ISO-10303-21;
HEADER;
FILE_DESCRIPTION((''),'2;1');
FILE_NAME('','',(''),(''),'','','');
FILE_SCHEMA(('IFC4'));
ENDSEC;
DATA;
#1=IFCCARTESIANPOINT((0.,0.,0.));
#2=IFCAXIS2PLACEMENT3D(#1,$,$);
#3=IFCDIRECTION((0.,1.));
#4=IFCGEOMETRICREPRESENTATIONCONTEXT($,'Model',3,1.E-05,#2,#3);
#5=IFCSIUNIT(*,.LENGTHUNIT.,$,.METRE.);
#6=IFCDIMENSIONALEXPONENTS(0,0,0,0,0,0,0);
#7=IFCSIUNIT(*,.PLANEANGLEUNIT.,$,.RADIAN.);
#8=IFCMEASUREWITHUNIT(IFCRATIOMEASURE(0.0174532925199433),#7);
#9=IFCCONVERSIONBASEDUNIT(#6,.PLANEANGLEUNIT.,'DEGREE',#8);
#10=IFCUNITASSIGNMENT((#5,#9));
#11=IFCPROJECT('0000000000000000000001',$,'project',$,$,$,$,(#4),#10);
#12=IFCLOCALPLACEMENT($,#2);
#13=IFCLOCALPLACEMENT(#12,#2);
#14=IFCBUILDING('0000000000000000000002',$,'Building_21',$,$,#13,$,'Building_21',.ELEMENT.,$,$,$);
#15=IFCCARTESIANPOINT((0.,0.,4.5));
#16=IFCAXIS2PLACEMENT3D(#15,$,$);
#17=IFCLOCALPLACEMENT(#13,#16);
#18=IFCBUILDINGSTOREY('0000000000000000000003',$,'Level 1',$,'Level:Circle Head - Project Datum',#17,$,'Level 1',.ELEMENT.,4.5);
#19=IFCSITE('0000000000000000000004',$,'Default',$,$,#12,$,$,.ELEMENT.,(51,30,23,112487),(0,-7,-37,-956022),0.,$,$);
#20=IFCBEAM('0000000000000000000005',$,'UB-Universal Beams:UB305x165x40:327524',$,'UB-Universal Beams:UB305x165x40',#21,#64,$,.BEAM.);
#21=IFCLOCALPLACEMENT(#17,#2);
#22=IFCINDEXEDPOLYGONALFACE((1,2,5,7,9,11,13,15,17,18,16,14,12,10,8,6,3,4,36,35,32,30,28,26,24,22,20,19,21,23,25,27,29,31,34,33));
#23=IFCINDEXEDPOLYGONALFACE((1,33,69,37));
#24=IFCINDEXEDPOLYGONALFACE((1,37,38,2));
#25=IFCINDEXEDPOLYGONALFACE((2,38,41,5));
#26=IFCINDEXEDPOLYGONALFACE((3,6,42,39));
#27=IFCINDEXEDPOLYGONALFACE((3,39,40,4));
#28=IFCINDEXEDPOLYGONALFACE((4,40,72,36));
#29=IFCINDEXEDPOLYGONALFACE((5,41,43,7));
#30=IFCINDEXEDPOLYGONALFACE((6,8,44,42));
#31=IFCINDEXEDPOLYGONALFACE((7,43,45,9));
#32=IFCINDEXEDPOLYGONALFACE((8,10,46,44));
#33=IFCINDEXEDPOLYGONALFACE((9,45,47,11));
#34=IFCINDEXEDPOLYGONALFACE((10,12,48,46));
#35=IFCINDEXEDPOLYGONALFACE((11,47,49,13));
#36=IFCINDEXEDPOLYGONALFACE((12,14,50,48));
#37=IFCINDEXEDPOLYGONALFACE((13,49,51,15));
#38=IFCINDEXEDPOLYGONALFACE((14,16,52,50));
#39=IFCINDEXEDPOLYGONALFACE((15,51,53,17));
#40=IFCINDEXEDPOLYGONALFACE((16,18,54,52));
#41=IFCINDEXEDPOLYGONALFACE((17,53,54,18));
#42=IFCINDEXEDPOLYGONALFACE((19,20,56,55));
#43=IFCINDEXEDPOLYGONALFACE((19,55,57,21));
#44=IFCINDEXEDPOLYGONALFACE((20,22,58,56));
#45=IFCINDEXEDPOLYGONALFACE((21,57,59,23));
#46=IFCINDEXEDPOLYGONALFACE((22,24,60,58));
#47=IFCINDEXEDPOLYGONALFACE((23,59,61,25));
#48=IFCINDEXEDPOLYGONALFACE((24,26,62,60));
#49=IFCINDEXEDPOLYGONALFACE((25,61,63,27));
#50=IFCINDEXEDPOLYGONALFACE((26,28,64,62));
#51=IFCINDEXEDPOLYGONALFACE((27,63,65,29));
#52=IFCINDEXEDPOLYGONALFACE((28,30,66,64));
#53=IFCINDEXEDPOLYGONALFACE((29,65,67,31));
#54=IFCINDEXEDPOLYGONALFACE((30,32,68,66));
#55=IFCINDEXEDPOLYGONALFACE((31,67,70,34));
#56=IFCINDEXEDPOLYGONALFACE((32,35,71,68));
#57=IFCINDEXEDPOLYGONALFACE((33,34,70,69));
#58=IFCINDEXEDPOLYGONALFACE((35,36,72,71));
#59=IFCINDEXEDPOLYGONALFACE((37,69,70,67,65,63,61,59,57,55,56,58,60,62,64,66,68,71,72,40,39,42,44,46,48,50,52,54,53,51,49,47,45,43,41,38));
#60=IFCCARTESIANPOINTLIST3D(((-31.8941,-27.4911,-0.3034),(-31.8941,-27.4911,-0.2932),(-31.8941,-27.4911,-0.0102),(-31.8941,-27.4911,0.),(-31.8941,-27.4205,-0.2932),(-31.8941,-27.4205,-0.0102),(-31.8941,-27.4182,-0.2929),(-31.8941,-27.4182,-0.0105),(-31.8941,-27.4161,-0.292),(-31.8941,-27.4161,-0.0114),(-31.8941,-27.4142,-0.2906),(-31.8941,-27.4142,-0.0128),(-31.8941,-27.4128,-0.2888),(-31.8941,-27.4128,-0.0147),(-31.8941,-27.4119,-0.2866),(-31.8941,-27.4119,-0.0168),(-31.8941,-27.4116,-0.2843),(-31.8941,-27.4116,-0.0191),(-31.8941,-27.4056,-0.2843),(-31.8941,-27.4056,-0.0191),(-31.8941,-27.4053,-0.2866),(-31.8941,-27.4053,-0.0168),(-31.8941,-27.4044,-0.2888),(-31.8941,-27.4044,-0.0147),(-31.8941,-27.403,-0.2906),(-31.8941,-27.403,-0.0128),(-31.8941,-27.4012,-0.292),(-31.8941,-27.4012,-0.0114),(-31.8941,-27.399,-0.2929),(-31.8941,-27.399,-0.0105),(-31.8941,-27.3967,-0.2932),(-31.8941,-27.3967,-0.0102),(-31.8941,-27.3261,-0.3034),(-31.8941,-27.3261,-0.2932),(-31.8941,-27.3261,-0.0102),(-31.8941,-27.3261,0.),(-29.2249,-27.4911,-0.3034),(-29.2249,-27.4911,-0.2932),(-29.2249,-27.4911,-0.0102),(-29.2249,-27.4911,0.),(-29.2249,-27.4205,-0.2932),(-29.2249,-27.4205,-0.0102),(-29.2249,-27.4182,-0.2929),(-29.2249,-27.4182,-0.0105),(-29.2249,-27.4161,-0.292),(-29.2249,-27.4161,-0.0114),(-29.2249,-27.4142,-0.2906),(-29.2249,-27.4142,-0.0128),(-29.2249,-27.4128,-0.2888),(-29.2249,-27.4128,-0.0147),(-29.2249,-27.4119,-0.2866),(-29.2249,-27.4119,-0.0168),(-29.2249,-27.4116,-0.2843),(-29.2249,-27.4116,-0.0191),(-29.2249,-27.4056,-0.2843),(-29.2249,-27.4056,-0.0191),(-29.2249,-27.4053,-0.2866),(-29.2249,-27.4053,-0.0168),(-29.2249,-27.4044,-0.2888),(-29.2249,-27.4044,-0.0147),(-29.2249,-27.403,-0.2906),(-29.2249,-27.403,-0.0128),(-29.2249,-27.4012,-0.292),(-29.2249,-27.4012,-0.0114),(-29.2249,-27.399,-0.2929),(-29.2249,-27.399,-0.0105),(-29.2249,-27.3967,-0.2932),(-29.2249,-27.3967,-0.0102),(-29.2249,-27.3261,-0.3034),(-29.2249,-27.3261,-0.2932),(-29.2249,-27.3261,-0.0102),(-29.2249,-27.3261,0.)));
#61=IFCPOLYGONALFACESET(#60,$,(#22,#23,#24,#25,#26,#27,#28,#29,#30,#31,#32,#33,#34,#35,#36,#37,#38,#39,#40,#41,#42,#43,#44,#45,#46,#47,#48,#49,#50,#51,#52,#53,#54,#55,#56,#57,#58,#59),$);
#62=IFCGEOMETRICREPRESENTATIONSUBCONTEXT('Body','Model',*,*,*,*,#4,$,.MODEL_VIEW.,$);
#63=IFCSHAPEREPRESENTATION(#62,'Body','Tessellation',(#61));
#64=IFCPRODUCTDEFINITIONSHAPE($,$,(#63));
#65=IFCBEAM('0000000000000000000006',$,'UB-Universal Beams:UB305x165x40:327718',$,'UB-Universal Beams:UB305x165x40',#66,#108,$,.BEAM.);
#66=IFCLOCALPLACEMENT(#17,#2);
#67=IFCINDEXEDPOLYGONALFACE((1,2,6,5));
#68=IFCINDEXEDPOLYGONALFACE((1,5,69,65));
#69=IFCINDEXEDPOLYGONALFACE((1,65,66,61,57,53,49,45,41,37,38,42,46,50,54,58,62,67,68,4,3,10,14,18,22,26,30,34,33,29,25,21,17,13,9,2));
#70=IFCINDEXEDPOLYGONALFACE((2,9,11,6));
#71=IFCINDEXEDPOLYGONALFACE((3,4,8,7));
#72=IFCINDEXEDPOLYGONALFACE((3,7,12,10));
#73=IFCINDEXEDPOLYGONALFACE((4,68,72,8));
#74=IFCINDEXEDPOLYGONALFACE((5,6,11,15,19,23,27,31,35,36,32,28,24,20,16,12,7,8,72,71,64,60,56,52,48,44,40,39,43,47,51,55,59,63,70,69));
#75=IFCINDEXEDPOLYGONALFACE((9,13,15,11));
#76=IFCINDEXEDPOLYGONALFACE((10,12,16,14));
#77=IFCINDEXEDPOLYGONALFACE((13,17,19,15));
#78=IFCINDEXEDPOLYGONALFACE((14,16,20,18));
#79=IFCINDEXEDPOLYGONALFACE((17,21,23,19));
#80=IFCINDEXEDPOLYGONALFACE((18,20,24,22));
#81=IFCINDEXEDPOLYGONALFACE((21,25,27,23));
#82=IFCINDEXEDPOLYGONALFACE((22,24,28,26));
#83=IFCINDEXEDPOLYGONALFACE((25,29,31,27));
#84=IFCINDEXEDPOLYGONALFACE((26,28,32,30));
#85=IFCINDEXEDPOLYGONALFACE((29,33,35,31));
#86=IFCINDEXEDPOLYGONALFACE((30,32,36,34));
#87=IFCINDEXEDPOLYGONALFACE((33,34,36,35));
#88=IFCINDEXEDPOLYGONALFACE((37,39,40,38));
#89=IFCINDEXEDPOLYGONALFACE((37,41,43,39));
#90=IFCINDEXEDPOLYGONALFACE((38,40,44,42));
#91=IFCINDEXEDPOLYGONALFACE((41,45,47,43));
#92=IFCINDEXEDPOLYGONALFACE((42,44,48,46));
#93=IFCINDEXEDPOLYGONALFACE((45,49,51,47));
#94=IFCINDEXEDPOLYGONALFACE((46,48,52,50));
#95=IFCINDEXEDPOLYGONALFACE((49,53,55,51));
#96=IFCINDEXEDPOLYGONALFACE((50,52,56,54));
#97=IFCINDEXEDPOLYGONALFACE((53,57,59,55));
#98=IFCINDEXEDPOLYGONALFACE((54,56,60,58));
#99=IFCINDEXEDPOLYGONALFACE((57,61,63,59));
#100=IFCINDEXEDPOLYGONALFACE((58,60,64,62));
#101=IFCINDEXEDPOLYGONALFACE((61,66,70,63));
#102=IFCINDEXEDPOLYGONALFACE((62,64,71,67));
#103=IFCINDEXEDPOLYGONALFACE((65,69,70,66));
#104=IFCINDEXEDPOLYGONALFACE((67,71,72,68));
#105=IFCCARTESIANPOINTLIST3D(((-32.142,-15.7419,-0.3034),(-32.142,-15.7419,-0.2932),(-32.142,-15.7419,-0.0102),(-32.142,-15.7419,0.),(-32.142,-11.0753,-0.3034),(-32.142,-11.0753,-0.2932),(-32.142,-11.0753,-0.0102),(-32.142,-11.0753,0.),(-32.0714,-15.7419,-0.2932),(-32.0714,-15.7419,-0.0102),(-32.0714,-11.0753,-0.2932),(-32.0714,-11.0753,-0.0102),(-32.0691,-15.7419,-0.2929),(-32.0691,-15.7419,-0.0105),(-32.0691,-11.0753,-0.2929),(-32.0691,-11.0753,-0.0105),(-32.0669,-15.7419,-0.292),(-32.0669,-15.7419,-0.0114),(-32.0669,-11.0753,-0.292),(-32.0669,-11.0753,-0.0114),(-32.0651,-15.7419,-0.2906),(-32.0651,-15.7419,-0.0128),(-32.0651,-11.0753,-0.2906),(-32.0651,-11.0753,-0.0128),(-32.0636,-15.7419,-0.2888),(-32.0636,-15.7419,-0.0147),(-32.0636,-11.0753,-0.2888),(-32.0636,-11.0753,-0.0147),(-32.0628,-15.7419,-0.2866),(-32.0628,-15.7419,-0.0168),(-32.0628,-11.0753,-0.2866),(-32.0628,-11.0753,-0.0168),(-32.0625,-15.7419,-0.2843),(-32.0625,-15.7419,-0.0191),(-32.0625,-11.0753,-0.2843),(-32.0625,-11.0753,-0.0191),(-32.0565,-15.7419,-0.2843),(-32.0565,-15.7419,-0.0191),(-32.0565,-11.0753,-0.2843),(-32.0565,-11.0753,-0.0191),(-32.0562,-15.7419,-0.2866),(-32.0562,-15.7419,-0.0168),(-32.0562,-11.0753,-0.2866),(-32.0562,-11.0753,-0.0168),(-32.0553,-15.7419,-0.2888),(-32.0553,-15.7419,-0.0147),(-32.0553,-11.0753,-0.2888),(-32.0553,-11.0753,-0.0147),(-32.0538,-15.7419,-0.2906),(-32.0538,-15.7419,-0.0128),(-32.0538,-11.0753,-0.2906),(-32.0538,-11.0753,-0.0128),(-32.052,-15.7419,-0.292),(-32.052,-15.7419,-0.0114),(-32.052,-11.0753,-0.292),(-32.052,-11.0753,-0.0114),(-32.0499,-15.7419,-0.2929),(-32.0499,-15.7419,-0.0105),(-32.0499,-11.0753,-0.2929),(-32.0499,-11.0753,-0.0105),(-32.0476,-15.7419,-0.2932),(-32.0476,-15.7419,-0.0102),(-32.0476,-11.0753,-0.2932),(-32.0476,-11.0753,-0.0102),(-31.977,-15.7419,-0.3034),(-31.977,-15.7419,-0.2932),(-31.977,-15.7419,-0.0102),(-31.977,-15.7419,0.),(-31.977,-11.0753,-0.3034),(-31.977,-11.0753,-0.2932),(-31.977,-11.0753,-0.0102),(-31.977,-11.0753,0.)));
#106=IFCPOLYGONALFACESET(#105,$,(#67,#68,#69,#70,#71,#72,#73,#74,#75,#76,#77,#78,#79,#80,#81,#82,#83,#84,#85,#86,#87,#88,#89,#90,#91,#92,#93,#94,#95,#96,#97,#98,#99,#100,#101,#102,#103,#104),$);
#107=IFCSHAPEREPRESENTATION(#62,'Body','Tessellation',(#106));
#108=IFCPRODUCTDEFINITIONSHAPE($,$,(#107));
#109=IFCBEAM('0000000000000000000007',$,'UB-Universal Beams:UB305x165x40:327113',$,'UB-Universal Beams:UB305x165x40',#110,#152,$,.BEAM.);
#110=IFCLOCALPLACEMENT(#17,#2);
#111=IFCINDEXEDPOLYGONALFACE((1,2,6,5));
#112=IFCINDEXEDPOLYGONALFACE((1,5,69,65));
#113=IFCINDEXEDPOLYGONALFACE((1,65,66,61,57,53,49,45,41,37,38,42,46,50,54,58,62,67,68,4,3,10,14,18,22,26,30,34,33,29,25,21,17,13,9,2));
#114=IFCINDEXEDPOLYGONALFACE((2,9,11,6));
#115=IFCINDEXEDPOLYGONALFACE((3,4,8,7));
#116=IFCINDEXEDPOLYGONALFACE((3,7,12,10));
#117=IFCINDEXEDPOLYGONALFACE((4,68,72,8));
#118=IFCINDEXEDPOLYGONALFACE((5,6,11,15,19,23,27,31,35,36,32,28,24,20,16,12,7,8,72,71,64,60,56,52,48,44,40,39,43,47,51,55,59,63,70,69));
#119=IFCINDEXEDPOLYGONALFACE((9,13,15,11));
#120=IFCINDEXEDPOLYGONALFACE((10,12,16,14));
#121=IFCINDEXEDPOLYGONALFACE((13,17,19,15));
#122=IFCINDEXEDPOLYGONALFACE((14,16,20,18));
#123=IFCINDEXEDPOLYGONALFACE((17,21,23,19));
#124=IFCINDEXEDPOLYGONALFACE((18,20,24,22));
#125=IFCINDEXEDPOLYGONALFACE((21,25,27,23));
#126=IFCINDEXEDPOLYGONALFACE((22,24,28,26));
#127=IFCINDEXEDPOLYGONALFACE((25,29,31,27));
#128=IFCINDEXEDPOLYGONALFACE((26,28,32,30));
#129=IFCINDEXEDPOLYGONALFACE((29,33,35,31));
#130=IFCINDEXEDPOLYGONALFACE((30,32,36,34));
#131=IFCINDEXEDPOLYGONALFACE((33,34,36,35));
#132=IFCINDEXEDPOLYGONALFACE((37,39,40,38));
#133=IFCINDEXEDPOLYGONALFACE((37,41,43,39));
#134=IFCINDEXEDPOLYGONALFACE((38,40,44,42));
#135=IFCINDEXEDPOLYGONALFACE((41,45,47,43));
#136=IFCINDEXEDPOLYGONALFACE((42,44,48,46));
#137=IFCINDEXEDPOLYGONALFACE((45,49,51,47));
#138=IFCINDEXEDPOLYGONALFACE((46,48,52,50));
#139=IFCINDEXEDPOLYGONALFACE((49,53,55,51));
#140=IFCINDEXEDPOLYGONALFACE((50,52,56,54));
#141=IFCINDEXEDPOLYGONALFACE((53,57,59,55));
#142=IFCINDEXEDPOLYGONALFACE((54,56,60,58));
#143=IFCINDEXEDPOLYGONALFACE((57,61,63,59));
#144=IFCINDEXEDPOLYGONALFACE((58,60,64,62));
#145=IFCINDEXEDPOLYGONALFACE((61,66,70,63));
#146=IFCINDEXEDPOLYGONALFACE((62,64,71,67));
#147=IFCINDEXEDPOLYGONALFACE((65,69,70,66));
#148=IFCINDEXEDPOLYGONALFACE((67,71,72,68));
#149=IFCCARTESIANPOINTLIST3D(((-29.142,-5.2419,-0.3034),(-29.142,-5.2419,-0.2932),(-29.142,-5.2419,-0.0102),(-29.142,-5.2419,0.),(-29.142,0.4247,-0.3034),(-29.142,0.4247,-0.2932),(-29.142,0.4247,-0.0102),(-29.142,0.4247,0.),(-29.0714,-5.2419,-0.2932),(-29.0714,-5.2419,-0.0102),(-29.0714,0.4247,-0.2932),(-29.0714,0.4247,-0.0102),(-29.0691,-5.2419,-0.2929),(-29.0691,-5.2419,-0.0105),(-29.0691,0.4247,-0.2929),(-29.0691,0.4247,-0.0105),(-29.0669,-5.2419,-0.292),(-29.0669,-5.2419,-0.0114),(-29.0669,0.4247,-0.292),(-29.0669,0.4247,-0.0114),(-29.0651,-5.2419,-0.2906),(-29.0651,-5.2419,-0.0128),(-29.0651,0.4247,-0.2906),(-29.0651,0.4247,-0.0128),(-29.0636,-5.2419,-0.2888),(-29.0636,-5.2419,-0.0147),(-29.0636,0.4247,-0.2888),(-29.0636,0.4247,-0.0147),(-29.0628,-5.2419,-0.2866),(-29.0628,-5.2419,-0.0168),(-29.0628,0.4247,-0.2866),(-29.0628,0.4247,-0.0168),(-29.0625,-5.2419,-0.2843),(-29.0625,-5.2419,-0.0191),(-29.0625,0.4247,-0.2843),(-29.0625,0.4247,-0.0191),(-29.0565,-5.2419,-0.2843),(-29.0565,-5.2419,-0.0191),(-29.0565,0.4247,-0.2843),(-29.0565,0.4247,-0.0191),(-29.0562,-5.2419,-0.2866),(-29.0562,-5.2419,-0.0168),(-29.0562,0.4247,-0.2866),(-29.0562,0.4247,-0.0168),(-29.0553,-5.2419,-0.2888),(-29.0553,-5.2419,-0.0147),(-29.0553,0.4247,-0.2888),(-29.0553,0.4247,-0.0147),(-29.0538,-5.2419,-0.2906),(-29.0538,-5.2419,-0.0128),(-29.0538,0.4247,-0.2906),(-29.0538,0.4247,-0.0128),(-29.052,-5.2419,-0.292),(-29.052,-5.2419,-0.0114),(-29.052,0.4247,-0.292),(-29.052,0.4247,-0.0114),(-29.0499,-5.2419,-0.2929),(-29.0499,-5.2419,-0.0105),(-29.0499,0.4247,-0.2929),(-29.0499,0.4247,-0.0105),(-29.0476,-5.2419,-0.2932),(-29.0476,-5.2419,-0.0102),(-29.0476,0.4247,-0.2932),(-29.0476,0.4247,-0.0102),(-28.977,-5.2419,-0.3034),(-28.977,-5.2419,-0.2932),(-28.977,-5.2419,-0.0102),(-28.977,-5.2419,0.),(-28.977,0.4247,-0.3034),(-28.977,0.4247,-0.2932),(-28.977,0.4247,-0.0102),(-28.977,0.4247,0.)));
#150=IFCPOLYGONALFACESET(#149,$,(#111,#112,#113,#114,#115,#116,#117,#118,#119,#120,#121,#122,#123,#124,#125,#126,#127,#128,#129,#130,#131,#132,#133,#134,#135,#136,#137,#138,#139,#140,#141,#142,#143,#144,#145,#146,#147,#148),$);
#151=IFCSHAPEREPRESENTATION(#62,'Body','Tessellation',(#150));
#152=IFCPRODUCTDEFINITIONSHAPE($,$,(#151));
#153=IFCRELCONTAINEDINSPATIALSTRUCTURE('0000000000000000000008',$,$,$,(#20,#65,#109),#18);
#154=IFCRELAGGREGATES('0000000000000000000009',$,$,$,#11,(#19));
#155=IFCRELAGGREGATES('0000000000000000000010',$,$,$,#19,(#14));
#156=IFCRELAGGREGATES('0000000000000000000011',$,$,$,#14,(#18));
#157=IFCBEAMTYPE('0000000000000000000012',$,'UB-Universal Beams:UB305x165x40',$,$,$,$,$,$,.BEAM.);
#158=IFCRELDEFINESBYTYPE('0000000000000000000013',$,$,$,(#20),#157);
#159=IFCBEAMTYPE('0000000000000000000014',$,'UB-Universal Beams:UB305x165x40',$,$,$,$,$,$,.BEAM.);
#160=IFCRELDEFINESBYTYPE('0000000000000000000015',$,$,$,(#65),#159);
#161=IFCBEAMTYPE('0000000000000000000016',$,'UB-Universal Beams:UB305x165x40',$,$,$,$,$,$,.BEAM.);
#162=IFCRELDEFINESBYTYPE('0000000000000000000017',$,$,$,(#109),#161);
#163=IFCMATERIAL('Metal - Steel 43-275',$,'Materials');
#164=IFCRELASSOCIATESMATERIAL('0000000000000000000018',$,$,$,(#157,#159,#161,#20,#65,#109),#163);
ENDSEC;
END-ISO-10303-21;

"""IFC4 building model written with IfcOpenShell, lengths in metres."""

from ifc_helpers import new_model, entity, si_unit, converted_unit, direction, frame, frame_2d, origin, place, context, subcontext, project, spatial, polyline, circle_curve, parameter, trimmed, segment, composite_curve, i_section, outline, extrude, source, transform, mapped, material, material_profile, profile_set, profile_usage, type_object, type_shapes, element, save


model = new_model("IFC4")

# Units and contexts
model_context = context("Model", 3, precision=1e-05, world=origin(), true_north=direction((0.0, 1.0)))
body_context = subcontext(model_context, "Body", "Model", "MODEL_VIEW")
ifc_project = project(units=[si_unit("LENGTHUNIT", "METRE"), converted_unit("PLANEANGLEUNIT", "DEGREE", entity("IfcRatioMeasure", 0.0174532925199433), si_unit("PLANEANGLEUNIT", "RADIAN"), dimensions=[0, 0, 0, 0, 0, 0, 0])], contexts=[model_context])

# Site, building, storey
site_placement = place(None, origin())
site = spatial("IfcSite", under=ifc_project, at=site_placement, Name="Default", CompositionType="ELEMENT", RefLatitude=(51, 30, 23, 112487), RefLongitude=(0, -7, -37, -956022), RefElevation=0.0)
building_placement = place(site_placement, origin())
building = spatial("IfcBuilding", under=site, at=building_placement, Name="Building_21", LongName="Building_21", CompositionType="ELEMENT")
storey_placement = place(building_placement, frame((0.0, 0.0, 4.5)))
storey = spatial("IfcBuildingStorey", under=building, at=storey_placement, Name="Level 1", ObjectType="Level:Circle Head - Project Datum", LongName="Level 1", CompositionType="ELEMENT", Elevation=4.5)

# Shared definitions
ifc_material_1 = material(Name="Metal - Steel 43-275", Category="Materials")

# Beams
ifc_material_profile_1 = material_profile(ifc_material_1, outline(composite_curve([segment(polyline([(0.0119, -0.1415, 0.0), (0.0825, -0.1415, 0.0)]), True, "CONTINUOUS"), segment(polyline([(0.0825, -0.1415, 0.0), (0.0825, -0.1517, 0.0)]), True, "CONTINUOUS"), segment(polyline([(0.0825, -0.1517, 0.0), (-0.0825, -0.1517, 0.0)]), True, "CONTINUOUS"), segment(polyline([(-0.0825, -0.1517, 0.0), (-0.0825, -0.1415, 0.0)]), True, "CONTINUOUS"), segment(polyline([(-0.0825, -0.1415, 0.0), (-0.0119, -0.1415, 0.0)]), True, "CONTINUOUS"), segment(trimmed(circle_curve(frame((-0.0119, -0.1326, 0.0), z_axis=(0.0, 0.0, 1.0), x_axis=(-1.0, 0.0, 0.0)), 0.0089), [parameter(90.0)], [parameter(180.0)], True, "PARAMETER"), True, "CONTINUOUS"), segment(polyline([(-0.003, -0.1326, 0.0), (-0.003, 0.1326, 0.0)]), True, "CONTINUOUS"), segment(trimmed(circle_curve(frame((-0.0119, 0.1326, 0.0), z_axis=(0.0, 0.0, 1.0), x_axis=(-1.0, 0.0, 0.0)), 0.0089), [parameter(180.0)], [parameter(270.0)], True, "PARAMETER"), True, "CONTINUOUS"), segment(polyline([(-0.0119, 0.1415, 0.0), (-0.0825, 0.1415, 0.0)]), True, "CONTINUOUS"), segment(polyline([(-0.0825, 0.1415, 0.0), (-0.0825, 0.1517, 0.0)]), True, "CONTINUOUS"), segment(polyline([(-0.0825, 0.1517, 0.0), (0.0825, 0.1517, 0.0)]), True, "CONTINUOUS"), segment(polyline([(0.0825, 0.1517, 0.0), (0.0825, 0.1415, 0.0)]), True, "CONTINUOUS"), segment(polyline([(0.0825, 0.1415, 0.0), (0.0119, 0.1415, 0.0)]), True, "CONTINUOUS"), segment(trimmed(circle_curve(frame((0.0119, 0.1326, 0.0), z_axis=(0.0, 0.0, 1.0), x_axis=(-1.0, 0.0, 0.0)), 0.0089), [parameter(270.0)], [parameter(0.0)], True, "PARAMETER"), True, "CONTINUOUS"), segment(polyline([(0.003, 0.1326, 0.0), (0.003, -0.1326, 0.0)]), True, "CONTINUOUS"), segment(trimmed(circle_curve(frame((0.0119, -0.1326, 0.0), z_axis=(0.0, 0.0, 1.0), x_axis=(-1.0, 0.0, 0.0)), 0.0089), [parameter(0.0)], [parameter(90.0)], True, "PARAMETER"), True, "CONTINUOUS")], self_intersect=False), kind="CURVE"), Name="UB305x165x40")
ifc_material_profile_2 = material_profile(ifc_material_1, outline(composite_curve([segment(polyline([(-1.3346, 0.0825, -0.1415), (-1.3346, 0.0825, -0.1517)]), True, "CONTINUOUS"), segment(polyline([(-1.3346, 0.0825, -0.1517), (-1.3346, -0.0825, -0.1517)]), True, "CONTINUOUS"), segment(polyline([(-1.3346, -0.0825, -0.1517), (-1.3346, -0.0825, -0.1415)]), True, "CONTINUOUS"), segment(polyline([(-1.3346, -0.0825, -0.1415), (-1.3346, -0.003, -0.1415)]), True, "CONTINUOUS"), segment(polyline([(-1.3346, -0.003, -0.1415), (-1.3346, -0.003, 0.1415)]), True, "CONTINUOUS"), segment(polyline([(-1.3346, -0.003, 0.1415), (-1.3346, -0.0825, 0.1415)]), True, "CONTINUOUS"), segment(polyline([(-1.3346, -0.0825, 0.1415), (-1.3346, -0.0825, 0.1517)]), True, "CONTINUOUS"), segment(polyline([(-1.3346, -0.0825, 0.1517), (-1.3346, 0.0825, 0.1517)]), True, "CONTINUOUS"), segment(polyline([(-1.3346, 0.0825, 0.1517), (-1.3346, 0.0825, 0.1415)]), True, "CONTINUOUS"), segment(polyline([(-1.3346, 0.0825, 0.1415), (-1.3346, 0.003, 0.1415)]), True, "CONTINUOUS"), segment(polyline([(-1.3346, 0.003, 0.1415), (-1.3346, 0.003, -0.1415)]), True, "CONTINUOUS"), segment(polyline([(-1.3346, 0.003, -0.1415), (-1.3346, 0.0825, -0.1415)]), True, "CONTINUOUS")], self_intersect=False), kind="CURVE"), Name="UB305x165x40")
ifc_profile_set_1 = profile_set([ifc_material_profile_1, ifc_material_profile_2], Name="UB305x165x40")
ifc_profile_usage_1 = profile_usage(ifc_profile_set_1, cardinal=8)
beam_type_1 = type_object("IfcBeamType", Name="UB-Universal Beams:UB305x165x40", PredefinedType="BEAM", material=ifc_profile_set_1)
shared_shape_1 = source(origin(), body_context, "Body", "SweptSolid", [
    extrude(i_section(OverallWidth=0.165, OverallDepth=0.3034, WebThickness=0.006, FlangeThickness=0.0102, FilletRadius=0.0089, at=frame_2d((0.0, 0.0), x_axis=(0.0, 1.0))), frame((-1.3346, 0.0, 0.0), z_axis=(1.0, 0.0, 0.0), x_axis=(0.0, 0.0, -1.0)), (0.0, 0.0, 1.0), 2.6692),
])
type_shapes(beam_type_1, [shared_shape_1])
beam_1_placement = place(storey_placement, frame((-30.5595, -27.4086, -0.1517)))
element("IfcBeam", 1, at=beam_1_placement, inside=storey, type_object=beam_type_1, material=ifc_profile_usage_1, Name="UB-Universal Beams:UB305x165x40:327524", ObjectType="UB-Universal Beams:UB305x165x40", PredefinedType="BEAM", context=body_context, shape_type="MappedRepresentation", body=[
    mapped(shared_shape_1, transform((0.0, 0.0, 0.0), scale=1.0)),
])
ifc_profile_usage_2 = profile_usage(ifc_profile_set_1, cardinal=8)
beam_type_2 = type_object("IfcBeamType", Name="UB-Universal Beams:UB305x165x40", PredefinedType="BEAM", material=ifc_profile_set_1)
shared_shape_2 = source(origin(), body_context, "Body", "SweptSolid", [
    extrude(i_section(OverallWidth=0.165, OverallDepth=0.3034, WebThickness=0.006, FlangeThickness=0.0102, FilletRadius=0.0089, at=frame_2d((0.0, 0.0), x_axis=(0.0, 1.0))), frame((-2.3333, 0.0, 0.0), z_axis=(1.0, 0.0, 0.0), x_axis=(0.0, 0.0, -1.0)), (0.0, 0.0, 1.0), 4.6666),
])
type_shapes(beam_type_2, [shared_shape_2])
beam_2_placement = place(storey_placement, frame((-32.0595, -13.4086, -0.1517), z_axis=(0.0, 0.0, 1.0), x_axis=(0.0, -1.0, 0.0)))
element("IfcBeam", 2, at=beam_2_placement, inside=storey, type_object=beam_type_2, material=ifc_profile_usage_2, Name="UB-Universal Beams:UB305x165x40:327718", ObjectType="UB-Universal Beams:UB305x165x40", PredefinedType="BEAM", context=body_context, shape_type="MappedRepresentation", body=[
    mapped(shared_shape_2, transform((0.0, 0.0, 0.0), scale=1.0)),
])
ifc_profile_usage_3 = profile_usage(ifc_profile_set_1, cardinal=8)
beam_type_3 = type_object("IfcBeamType", Name="UB-Universal Beams:UB305x165x40", PredefinedType="BEAM", material=ifc_profile_set_1)
shared_shape_3 = source(origin(), body_context, "Body", "SweptSolid", [
    extrude(i_section(OverallWidth=0.165, OverallDepth=0.3034, WebThickness=0.006, FlangeThickness=0.0102, FilletRadius=0.0089, at=frame_2d((0.0, 0.0), x_axis=(0.0, 1.0))), frame((-2.8333, 0.0, 0.0), z_axis=(1.0, 0.0, 0.0), x_axis=(0.0, 0.0, -1.0)), (0.0, 0.0, 1.0), 5.6666),
])
type_shapes(beam_type_3, [shared_shape_3])
beam_3_placement = place(storey_placement, frame((-29.0595, -2.4086, -0.1517), z_axis=(0.0, 0.0, 1.0), x_axis=(0.0, 1.0, 0.0)))
element("IfcBeam", 3, at=beam_3_placement, inside=storey, type_object=beam_type_3, material=ifc_profile_usage_3, Name="UB-Universal Beams:UB305x165x40:327113", ObjectType="UB-Universal Beams:UB305x165x40", PredefinedType="BEAM", context=body_context, shape_type="MappedRepresentation", body=[
    mapped(shared_shape_3, transform((0.0, 0.0, 0.0), scale=1.0)),
])

save(model, "model.ifc")
